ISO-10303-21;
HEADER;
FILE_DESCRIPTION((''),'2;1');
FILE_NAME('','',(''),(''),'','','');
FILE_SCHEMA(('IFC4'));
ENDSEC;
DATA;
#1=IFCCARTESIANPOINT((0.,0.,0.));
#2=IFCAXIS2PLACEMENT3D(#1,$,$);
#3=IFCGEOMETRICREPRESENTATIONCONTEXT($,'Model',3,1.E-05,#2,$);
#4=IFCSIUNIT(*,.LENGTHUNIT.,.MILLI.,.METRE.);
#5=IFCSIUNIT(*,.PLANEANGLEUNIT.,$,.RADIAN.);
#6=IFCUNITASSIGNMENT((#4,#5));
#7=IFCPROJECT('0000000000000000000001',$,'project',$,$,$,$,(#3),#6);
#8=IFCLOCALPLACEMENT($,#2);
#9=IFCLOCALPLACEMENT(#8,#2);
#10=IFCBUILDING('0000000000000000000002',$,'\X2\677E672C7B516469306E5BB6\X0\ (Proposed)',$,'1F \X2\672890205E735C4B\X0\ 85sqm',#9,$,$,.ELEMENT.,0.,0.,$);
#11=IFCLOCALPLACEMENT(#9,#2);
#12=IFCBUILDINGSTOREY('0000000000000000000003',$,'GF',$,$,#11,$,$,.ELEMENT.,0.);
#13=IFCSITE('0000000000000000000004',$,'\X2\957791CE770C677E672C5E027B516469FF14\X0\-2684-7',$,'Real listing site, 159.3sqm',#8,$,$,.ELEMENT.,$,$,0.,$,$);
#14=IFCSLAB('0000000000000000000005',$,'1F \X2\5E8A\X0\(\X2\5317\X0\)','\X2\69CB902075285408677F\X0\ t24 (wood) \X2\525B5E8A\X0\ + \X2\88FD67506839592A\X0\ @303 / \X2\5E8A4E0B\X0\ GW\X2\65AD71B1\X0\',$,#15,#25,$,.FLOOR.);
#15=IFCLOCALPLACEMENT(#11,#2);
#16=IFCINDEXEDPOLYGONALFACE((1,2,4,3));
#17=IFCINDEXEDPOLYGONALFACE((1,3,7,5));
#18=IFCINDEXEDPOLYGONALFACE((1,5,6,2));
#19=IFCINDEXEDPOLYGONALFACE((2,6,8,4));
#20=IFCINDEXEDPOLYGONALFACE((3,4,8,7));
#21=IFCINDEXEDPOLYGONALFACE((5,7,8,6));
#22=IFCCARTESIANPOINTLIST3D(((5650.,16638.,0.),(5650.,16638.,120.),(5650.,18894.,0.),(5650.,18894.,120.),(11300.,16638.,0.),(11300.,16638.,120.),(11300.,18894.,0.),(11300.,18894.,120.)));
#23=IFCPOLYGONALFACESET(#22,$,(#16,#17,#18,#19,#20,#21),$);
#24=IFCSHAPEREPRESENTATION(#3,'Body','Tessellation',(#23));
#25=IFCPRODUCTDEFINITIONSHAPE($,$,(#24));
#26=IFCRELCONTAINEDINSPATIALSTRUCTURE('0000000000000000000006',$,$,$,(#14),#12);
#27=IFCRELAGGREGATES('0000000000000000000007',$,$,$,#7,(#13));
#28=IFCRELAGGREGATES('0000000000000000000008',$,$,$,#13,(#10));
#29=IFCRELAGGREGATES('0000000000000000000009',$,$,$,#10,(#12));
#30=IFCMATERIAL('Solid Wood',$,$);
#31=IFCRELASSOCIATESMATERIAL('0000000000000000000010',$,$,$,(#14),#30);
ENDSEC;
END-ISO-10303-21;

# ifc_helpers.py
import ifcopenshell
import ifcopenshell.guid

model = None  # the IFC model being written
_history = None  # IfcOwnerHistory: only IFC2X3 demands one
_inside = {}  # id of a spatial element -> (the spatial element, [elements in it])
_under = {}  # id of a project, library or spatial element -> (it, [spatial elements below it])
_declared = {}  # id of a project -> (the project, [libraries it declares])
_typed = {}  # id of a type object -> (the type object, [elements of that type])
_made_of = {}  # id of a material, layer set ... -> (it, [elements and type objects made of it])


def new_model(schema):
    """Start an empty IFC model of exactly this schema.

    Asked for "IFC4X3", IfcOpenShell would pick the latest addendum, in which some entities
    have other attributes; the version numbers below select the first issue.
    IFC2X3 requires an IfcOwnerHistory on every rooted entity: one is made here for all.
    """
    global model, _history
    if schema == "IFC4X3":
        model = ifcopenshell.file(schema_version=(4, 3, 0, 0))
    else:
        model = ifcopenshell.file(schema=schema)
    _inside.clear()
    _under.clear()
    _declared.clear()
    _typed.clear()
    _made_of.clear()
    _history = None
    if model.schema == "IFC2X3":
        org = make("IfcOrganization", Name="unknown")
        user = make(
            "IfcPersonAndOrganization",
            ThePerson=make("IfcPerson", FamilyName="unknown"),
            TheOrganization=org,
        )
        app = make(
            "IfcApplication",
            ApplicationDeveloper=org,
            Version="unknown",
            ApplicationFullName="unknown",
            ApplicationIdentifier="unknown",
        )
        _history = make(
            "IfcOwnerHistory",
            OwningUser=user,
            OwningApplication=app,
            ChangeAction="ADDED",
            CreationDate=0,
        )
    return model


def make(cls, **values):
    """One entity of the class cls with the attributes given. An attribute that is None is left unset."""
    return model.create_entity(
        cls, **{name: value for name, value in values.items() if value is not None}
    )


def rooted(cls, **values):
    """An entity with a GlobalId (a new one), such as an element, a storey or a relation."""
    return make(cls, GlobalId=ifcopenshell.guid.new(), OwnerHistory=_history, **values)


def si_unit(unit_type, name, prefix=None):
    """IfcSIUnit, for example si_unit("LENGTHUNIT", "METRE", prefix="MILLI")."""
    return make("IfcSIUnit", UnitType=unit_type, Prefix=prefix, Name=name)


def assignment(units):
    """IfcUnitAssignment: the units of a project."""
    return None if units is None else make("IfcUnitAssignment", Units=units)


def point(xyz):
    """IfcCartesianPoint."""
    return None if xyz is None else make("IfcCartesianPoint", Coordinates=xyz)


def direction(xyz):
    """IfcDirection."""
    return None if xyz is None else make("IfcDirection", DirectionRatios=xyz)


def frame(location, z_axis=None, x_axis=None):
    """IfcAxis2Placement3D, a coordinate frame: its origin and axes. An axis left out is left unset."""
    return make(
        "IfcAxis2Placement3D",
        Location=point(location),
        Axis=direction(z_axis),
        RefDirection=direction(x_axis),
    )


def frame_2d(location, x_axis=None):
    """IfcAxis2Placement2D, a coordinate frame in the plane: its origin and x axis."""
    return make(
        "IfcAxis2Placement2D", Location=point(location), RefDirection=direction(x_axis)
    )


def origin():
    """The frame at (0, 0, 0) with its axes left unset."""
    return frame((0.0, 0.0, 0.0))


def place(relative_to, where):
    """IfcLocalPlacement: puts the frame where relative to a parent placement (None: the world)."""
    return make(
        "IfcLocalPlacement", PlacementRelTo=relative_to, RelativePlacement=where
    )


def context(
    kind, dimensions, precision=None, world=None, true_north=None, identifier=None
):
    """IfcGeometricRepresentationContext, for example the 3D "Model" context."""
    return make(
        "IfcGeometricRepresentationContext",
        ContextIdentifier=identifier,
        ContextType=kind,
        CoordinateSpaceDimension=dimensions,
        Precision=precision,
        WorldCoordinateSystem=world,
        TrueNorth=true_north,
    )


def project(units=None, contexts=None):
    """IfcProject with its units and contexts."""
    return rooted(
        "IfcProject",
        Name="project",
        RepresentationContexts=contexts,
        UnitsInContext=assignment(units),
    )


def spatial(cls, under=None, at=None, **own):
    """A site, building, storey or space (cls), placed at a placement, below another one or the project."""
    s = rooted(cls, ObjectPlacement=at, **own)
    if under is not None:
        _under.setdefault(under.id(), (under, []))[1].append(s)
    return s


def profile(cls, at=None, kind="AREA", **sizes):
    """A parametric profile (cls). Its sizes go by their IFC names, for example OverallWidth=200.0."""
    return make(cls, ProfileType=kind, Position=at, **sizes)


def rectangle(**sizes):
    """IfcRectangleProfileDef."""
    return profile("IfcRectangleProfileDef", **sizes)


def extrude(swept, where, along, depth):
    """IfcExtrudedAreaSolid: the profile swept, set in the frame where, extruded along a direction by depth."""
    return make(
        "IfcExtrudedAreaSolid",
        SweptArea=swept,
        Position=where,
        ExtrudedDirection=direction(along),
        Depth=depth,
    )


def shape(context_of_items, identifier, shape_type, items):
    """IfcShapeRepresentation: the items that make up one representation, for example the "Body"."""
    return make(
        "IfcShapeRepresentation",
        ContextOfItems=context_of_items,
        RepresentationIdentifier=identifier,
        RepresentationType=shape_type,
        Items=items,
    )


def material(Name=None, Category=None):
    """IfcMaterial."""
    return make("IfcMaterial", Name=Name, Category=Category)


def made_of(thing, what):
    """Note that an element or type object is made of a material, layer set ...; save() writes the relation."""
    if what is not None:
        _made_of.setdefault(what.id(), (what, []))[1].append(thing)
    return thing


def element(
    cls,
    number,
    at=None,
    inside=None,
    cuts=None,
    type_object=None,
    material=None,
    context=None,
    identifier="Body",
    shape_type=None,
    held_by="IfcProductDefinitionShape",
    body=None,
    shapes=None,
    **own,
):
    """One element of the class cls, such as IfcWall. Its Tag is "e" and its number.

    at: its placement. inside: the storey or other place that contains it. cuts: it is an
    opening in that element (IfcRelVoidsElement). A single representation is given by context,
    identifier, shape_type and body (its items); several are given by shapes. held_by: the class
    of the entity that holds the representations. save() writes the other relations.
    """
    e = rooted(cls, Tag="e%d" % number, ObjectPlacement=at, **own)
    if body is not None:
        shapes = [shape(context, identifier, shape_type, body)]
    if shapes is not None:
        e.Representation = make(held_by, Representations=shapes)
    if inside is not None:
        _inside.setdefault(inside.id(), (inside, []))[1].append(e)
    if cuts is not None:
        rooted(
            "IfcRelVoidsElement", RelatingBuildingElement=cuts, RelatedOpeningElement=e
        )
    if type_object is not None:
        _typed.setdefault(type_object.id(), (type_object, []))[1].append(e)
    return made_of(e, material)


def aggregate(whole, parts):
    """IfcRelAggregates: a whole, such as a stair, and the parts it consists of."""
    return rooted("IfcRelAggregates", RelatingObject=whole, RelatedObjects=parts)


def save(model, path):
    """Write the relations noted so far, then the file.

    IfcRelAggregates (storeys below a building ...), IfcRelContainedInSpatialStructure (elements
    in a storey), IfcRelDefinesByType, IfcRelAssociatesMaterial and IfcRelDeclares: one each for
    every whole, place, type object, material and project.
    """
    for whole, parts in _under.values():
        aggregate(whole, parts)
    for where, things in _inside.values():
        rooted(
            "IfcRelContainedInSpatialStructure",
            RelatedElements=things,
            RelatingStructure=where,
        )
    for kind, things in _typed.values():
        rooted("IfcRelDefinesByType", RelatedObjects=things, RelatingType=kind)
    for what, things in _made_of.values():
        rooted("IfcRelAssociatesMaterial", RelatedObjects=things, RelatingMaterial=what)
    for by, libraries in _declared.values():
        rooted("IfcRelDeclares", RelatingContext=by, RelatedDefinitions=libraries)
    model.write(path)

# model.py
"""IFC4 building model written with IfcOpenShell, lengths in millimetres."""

from ifc_helpers import new_model, si_unit, frame, frame_2d, origin, place, context, project, spatial, rectangle, extrude, material, element, save


model = new_model("IFC4")

# Units and contexts
model_context = context("Model", 3, precision=1e-05, world=origin())
ifc_project = project(units=[si_unit("LENGTHUNIT", "METRE", prefix="MILLI"), si_unit("PLANEANGLEUNIT", "RADIAN")], contexts=[model_context])

# Site, building, storey
site_placement = place(None, origin())
site = spatial("IfcSite", under=ifc_project, at=site_placement, Name="長野県松本市筑摩４-2684-7", ObjectType="Real listing site, 159.3sqm", CompositionType="ELEMENT", RefElevation=0.0)
building_placement = place(site_placement, origin())
building = spatial("IfcBuilding", under=site, at=building_placement, Name="松本筑摩の家 (Proposed)", ObjectType="1F 木造平屋 85sqm", CompositionType="ELEMENT", ElevationOfRefHeight=0.0, ElevationOfTerrain=0.0)
storey_placement = place(building_placement, origin())
storey = spatial("IfcBuildingStorey", under=building, at=storey_placement, Name="GF", CompositionType="ELEMENT", Elevation=0.0)

# Slab
ifc_material_1 = material(Name="Solid Wood")
slab_1_placement = place(storey_placement, frame((2825.0, 8319.0, 0.0)))
element("IfcSlab", 1, at=slab_1_placement, inside=storey, material=ifc_material_1, Name="1F 床(北)", Description="構造用合板 t24 (wood) 剛床 + 製材根太 @303 / 床下 GW断熱", PredefinedType="FLOOR", context=model_context, shape_type="SweptSolid", body=[
    extrude(rectangle(XDim=5650.0, YDim=2256.0, at=frame_2d((2825.0, 1128.0))), frame((2825.0, 8319.0, 0.0)), (0.0, 0.0, 1.0), 120.0),
])

save(model, "model.ifc")
